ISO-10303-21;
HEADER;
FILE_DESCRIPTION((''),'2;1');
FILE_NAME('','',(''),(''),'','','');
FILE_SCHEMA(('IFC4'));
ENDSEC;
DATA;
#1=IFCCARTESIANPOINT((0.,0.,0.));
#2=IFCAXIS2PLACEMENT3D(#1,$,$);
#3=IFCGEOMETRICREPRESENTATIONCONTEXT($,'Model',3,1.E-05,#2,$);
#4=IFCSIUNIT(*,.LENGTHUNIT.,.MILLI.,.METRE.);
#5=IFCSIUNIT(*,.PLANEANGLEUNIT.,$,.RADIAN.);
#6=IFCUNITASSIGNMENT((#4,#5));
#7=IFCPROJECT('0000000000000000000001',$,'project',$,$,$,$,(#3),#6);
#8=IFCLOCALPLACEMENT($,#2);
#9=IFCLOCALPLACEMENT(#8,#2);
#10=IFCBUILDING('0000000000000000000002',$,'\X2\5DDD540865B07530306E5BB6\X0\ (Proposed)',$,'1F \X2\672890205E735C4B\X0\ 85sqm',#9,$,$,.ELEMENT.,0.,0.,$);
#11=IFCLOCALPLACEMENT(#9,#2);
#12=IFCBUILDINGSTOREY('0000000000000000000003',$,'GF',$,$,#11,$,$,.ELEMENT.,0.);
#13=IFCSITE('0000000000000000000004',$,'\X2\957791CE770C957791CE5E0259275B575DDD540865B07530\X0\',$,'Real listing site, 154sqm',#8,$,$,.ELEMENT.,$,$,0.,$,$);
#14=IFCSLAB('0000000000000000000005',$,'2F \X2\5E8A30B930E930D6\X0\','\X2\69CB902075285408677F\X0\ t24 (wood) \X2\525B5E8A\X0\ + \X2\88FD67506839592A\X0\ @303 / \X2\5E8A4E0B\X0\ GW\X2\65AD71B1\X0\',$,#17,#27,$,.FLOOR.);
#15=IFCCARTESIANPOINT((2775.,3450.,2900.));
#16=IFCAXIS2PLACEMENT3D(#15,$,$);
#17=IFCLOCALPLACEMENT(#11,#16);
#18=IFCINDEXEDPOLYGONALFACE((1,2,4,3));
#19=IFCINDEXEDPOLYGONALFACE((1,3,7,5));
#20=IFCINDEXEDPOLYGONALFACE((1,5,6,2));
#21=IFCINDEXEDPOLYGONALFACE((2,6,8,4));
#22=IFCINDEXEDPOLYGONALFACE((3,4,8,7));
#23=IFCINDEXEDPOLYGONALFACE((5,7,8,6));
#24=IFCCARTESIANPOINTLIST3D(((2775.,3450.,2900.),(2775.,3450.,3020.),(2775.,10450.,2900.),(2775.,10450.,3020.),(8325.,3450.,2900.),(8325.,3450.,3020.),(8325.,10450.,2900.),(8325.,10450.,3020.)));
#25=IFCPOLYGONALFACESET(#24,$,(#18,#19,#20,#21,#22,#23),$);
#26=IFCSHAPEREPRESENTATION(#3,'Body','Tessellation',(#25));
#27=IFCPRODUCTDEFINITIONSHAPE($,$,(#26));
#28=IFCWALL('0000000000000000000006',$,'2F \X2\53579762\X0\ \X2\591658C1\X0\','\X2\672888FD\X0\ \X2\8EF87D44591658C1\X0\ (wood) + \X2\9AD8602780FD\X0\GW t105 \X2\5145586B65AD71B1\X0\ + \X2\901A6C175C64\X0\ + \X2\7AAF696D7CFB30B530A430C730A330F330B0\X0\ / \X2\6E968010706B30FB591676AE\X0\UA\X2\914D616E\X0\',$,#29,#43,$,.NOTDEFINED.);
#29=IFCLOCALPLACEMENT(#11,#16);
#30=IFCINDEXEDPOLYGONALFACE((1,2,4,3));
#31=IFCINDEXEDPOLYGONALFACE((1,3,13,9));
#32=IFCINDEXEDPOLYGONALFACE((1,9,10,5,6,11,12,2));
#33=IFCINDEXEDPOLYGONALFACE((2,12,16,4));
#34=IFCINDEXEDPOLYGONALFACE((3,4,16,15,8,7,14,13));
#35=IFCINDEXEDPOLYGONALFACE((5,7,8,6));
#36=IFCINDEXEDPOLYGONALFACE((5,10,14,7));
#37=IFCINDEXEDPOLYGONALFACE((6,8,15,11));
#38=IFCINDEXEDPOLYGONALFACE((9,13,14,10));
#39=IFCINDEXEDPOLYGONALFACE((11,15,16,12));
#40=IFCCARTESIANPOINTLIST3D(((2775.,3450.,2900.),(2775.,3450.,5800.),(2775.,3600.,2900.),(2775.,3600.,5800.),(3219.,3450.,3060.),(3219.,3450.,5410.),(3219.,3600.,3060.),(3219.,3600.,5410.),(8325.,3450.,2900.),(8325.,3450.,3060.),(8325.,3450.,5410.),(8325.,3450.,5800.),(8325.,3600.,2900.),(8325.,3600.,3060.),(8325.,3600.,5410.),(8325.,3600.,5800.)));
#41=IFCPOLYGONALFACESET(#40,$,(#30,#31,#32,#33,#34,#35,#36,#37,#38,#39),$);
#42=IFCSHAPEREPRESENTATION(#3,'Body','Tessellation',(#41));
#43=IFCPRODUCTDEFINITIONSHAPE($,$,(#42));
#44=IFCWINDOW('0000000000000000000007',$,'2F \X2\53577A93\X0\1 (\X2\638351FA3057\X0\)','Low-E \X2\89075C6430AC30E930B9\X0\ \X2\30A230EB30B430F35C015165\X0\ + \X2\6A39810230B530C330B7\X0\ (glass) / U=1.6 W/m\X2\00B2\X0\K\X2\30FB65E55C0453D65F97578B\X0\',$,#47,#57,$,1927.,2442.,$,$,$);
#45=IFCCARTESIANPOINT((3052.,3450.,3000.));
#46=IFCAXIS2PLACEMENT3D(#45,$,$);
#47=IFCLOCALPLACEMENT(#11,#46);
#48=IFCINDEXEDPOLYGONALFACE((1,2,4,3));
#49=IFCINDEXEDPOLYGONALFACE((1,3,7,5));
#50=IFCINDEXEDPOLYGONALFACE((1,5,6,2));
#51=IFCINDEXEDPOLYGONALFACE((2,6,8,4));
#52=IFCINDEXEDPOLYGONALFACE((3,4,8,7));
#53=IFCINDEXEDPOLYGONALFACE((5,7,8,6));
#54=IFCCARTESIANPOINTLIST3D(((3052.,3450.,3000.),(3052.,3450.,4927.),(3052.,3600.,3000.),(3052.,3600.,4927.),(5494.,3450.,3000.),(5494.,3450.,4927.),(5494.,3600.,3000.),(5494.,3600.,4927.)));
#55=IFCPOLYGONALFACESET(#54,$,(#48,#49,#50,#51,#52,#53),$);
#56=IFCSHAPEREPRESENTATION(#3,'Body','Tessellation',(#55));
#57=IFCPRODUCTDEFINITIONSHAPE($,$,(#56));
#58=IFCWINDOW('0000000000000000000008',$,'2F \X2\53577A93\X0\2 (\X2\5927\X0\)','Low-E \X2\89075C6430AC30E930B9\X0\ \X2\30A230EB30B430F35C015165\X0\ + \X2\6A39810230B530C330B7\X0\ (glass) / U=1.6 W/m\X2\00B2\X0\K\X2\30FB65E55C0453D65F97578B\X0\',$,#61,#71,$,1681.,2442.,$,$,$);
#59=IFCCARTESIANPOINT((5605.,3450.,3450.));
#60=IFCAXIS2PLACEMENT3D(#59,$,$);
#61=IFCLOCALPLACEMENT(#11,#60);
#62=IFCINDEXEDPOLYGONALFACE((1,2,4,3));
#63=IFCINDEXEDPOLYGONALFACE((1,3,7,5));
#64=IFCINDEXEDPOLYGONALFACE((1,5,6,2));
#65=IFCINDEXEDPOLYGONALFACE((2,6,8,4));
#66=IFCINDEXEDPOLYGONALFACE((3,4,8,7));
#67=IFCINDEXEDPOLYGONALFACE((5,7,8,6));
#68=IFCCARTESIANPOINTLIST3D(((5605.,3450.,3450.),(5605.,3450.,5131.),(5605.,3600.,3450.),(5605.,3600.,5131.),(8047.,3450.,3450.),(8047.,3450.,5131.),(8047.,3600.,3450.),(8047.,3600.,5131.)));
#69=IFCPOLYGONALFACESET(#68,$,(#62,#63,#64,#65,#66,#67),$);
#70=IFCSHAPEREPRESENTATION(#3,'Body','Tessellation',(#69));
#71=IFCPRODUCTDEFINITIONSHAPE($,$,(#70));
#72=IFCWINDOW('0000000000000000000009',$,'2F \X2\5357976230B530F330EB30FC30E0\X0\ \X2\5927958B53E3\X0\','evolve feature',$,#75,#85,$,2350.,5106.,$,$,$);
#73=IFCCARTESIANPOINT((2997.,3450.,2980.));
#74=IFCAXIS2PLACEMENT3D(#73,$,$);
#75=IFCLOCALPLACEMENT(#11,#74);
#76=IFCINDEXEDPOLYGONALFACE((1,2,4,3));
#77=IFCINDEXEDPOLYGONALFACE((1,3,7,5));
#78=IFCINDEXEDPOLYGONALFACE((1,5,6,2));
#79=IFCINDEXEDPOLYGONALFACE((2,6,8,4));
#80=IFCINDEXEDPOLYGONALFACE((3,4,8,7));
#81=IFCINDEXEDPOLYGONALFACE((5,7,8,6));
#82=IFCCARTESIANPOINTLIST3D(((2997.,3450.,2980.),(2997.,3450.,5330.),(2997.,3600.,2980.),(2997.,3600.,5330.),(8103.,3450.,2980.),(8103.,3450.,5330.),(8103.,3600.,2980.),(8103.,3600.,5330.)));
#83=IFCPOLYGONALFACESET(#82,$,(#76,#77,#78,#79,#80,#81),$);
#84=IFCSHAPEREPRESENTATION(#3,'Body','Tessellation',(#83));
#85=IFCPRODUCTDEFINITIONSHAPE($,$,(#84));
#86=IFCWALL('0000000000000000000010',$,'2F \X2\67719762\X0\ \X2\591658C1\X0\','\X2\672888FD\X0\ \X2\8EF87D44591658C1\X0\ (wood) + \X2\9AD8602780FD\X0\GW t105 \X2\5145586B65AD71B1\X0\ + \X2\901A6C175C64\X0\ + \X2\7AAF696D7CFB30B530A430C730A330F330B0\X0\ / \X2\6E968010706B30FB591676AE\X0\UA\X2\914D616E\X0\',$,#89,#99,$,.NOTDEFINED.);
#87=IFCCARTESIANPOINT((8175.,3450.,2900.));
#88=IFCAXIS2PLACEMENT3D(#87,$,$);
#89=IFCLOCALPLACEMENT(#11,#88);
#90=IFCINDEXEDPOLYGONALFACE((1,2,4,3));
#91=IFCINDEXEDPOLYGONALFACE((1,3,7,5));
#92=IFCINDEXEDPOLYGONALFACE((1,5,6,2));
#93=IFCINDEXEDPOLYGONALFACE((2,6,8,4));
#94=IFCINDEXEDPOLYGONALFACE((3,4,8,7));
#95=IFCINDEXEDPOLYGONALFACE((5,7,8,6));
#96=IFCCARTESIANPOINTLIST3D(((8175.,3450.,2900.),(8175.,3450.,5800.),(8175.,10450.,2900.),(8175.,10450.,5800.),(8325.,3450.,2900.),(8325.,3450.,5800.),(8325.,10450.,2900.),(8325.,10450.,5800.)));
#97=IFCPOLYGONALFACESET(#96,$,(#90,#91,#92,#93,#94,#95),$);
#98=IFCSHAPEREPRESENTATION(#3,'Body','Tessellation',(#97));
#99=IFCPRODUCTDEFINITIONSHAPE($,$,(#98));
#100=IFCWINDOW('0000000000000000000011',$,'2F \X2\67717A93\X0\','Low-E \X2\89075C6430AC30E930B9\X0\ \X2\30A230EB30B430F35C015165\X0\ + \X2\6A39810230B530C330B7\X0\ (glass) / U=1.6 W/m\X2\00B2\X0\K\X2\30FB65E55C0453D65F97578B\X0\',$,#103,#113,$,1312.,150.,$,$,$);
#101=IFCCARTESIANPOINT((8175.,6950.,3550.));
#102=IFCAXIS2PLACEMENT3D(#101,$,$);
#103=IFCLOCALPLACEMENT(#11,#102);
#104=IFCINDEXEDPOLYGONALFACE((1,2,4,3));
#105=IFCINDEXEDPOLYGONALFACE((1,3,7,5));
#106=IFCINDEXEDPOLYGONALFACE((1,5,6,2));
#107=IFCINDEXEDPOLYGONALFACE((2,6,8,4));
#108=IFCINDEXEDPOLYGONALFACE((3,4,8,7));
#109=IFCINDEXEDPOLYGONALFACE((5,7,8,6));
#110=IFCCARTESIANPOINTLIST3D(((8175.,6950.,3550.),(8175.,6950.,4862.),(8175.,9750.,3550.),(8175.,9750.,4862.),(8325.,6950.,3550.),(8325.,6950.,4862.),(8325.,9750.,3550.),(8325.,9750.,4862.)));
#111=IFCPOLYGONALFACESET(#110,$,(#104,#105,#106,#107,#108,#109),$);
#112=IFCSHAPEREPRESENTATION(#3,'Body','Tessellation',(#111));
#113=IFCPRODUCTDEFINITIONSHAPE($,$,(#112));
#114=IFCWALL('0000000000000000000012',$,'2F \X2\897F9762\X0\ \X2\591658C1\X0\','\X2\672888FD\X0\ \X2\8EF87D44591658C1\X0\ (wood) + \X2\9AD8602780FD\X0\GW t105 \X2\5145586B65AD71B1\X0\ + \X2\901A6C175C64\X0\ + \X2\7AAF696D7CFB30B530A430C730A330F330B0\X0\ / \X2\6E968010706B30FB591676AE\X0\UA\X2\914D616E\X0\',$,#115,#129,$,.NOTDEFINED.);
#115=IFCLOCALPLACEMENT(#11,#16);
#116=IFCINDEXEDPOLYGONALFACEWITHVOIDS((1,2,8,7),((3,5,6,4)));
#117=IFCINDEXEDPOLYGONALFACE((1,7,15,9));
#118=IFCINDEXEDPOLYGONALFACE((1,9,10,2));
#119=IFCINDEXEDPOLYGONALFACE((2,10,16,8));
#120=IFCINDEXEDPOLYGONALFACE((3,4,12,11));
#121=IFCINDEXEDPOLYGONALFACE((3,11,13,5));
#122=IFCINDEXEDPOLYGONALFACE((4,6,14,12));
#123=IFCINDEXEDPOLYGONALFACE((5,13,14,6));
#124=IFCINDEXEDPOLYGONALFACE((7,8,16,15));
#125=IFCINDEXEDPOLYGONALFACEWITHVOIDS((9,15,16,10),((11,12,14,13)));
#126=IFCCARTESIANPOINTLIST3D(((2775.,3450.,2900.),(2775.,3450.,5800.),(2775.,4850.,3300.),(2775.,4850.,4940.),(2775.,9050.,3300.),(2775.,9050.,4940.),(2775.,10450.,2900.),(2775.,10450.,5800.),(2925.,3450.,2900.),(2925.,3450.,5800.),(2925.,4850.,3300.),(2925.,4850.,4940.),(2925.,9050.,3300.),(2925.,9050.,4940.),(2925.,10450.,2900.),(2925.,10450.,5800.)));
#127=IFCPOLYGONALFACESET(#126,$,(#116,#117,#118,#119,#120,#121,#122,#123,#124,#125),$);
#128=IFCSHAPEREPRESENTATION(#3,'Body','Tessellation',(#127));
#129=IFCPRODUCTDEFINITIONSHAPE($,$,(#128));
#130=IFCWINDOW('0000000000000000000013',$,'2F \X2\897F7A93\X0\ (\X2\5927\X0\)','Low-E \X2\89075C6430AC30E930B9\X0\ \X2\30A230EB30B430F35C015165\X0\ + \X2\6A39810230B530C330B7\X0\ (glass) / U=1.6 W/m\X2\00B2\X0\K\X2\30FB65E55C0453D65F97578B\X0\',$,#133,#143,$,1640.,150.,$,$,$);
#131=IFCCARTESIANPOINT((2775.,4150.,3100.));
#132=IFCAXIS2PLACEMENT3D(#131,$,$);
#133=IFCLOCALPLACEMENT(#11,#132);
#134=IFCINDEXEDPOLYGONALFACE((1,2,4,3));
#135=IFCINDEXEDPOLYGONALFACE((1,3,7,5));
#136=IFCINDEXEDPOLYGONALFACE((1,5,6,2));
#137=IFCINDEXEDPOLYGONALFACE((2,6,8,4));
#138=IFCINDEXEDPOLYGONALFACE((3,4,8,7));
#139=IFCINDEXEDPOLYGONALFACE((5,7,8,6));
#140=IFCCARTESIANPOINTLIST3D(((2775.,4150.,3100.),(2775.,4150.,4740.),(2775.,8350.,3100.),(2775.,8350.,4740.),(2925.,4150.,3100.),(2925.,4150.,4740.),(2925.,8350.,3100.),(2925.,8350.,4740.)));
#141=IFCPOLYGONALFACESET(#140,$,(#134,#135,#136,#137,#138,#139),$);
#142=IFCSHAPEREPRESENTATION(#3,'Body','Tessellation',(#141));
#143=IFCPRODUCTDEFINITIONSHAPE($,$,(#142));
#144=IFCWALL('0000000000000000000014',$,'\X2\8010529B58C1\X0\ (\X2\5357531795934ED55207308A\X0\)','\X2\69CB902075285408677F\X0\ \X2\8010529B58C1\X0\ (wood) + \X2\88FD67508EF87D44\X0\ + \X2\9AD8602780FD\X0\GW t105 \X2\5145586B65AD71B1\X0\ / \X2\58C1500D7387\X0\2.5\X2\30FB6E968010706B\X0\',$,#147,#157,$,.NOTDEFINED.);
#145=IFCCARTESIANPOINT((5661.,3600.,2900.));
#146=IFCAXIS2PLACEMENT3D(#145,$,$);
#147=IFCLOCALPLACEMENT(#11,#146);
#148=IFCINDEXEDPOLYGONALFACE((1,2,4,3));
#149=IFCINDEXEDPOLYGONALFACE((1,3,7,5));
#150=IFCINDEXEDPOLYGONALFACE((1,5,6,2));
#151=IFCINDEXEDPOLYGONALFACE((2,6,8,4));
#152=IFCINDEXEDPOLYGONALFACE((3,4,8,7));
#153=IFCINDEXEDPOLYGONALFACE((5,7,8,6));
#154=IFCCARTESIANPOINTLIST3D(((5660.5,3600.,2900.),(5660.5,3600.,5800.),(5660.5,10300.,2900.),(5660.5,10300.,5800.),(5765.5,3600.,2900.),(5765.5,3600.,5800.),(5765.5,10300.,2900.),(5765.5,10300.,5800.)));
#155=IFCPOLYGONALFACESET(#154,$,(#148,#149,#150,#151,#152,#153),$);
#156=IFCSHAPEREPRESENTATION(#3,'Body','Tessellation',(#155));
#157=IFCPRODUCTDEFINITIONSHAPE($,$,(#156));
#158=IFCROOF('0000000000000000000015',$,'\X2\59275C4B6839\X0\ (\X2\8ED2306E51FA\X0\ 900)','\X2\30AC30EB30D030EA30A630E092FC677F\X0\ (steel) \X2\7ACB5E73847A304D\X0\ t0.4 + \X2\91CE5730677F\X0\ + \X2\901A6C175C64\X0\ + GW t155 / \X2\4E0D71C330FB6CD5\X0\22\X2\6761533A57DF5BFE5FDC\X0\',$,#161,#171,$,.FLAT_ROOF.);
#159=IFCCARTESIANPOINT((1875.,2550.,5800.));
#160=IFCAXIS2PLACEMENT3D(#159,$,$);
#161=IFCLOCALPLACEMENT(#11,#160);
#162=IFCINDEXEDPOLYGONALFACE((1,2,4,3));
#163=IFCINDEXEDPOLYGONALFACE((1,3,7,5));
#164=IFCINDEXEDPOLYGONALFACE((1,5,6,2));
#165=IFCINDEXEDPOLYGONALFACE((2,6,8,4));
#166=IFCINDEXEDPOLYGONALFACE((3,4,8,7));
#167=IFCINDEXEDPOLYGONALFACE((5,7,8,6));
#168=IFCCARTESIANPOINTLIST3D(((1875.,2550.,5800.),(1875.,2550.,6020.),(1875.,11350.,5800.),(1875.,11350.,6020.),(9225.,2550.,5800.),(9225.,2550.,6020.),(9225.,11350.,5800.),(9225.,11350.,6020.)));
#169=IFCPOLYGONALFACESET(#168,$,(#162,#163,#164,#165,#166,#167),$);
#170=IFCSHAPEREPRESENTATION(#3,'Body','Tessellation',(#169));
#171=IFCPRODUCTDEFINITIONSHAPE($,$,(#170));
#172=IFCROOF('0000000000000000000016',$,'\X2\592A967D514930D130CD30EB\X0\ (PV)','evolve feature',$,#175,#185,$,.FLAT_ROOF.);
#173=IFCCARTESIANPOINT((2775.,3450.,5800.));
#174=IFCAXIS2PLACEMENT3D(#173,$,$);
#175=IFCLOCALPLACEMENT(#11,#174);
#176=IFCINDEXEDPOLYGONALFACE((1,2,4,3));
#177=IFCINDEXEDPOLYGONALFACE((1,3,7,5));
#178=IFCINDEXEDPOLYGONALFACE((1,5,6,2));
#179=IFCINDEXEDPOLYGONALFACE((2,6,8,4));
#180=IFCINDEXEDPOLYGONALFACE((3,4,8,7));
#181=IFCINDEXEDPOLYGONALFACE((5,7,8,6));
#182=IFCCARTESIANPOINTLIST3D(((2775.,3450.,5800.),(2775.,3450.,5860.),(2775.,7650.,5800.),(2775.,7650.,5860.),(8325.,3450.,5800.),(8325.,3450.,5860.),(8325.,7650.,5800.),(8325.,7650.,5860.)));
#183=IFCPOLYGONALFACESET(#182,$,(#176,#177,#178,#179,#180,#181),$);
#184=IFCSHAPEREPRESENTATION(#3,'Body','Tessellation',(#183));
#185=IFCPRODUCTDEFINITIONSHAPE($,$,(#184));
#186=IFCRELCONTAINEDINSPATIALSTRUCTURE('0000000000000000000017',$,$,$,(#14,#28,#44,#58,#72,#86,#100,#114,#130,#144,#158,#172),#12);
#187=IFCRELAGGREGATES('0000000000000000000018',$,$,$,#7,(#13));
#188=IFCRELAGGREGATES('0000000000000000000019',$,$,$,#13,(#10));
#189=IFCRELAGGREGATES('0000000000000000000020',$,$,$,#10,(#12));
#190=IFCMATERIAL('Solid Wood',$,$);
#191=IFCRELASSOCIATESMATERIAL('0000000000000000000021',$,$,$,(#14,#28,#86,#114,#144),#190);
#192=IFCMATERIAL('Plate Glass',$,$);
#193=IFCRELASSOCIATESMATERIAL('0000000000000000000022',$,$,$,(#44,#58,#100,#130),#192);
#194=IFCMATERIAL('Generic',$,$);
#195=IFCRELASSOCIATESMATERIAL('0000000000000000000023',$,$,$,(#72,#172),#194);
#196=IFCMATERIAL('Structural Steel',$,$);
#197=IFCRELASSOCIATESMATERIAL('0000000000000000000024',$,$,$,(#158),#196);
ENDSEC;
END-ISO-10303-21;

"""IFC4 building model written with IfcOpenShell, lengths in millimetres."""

from ifc_helpers import new_model, si_unit, frame, frame_2d, origin, place, context, project, spatial, rectangle, extrude, material, element, fill, save


model = new_model("IFC4")

# Units and contexts
model_context = context("Model", 3, precision=1e-05, world=origin())
ifc_project = project(units=[si_unit("LENGTHUNIT", "METRE", prefix="MILLI"), si_unit("PLANEANGLEUNIT", "RADIAN")], contexts=[model_context])

# Site, building, storey
site_placement = place(None, origin())
site = spatial("IfcSite", under=ifc_project, at=site_placement, Name="長野県長野市大字川合新田", ObjectType="Real listing site, 154sqm", CompositionType="ELEMENT", RefElevation=0.0)
building_placement = place(site_placement, origin())
building = spatial("IfcBuilding", under=site, at=building_placement, Name="川合新田の家 (Proposed)", ObjectType="1F 木造平屋 85sqm", CompositionType="ELEMENT", ElevationOfRefHeight=0.0, ElevationOfTerrain=0.0)
storey_placement = place(building_placement, origin())
storey = spatial("IfcBuildingStorey", under=building, at=storey_placement, Name="GF", CompositionType="ELEMENT", Elevation=0.0)

# Slab
ifc_material_1 = material(Name="Solid Wood")
slab_placement = place(storey_placement, frame((2775.0, 3450.0, 2900.0)))
element("IfcSlab", 1, at=slab_placement, inside=storey, material=ifc_material_1, Name="2F 床スラブ", Description="構造用合板 t24 (wood) 剛床 + 製材根太 @303 / 床下 GW断熱", PredefinedType="FLOOR", context=model_context, shape_type="SweptSolid", body=[
    extrude(rectangle(XDim=5550.0, YDim=7000.0, at=frame_2d((2775.0, 3500.0))), frame((2775.0, 3450.0, 2900.0)), (0.0, 0.0, 1.0), 120.0),
])

# Wall, openings, windows
wall_1_placement = place(storey_placement, frame((2775.0, 3450.0, 2900.0)))
wall_1 = element("IfcWall", 2, at=wall_1_placement, inside=storey, material=ifc_material_1, Name="2F 南面 外壁", Description="木製 軸組外壁 (wood) + 高性能GW t105 充填断熱 + 通気層 + 窯業系サイディング / 準耐火・外皮UA配慮", PredefinedType="NOTDEFINED", context=model_context, shape_type="SweptSolid", body=[
    extrude(rectangle(XDim=5550.0, YDim=150.0, at=frame_2d((2775.0, 75.0))), frame((2775.0, 3450.0, 2900.0)), (0.0, 0.0, 1.0), 2900.0),
])
opening_1_placement = place(storey_placement, frame((3052.0, 3450.0, 3000.0)))
opening_1 = element("IfcOpeningElement", 3, at=opening_1_placement, cuts=wall_1, PredefinedType="NOTDEFINED", context=model_context, shape_type="SweptSolid", body=[
    extrude(rectangle(XDim=2442.0, YDim=150.0, at=frame_2d((1221.0, 75.0))), frame((3052.0, 3450.0, 3000.0)), (0.0, 0.0, 1.0), 1927.0),
])
opening_2_placement = place(storey_placement, frame((5605.0, 3450.0, 3450.0)))
opening_2 = element("IfcOpeningElement", 4, at=opening_2_placement, cuts=wall_1, PredefinedType="NOTDEFINED", context=model_context, shape_type="SweptSolid", body=[
    extrude(rectangle(XDim=2442.0, YDim=150.0, at=frame_2d((1221.0, 75.0))), frame((5605.0, 3450.0, 3450.0)), (0.0, 0.0, 1.0), 1681.0),
])
opening_3_placement = place(storey_placement, frame((2997.0, 3450.0, 2980.0)))
opening_3 = element("IfcOpeningElement", 5, at=opening_3_placement, cuts=wall_1, PredefinedType="NOTDEFINED", context=model_context, shape_type="SweptSolid", body=[
    extrude(rectangle(XDim=5106.0, YDim=150.0, at=frame_2d((2553.0, 75.0))), frame((2997.0, 3450.0, 2980.0)), (0.0, 0.0, 1.0), 2350.0),
])
ifc_material_2 = material(Name="Plate Glass")
window_1_placement = place(storey_placement, frame((3052.0, 3450.0, 3000.0)))
window_1 = element("IfcWindow", 6, at=window_1_placement, inside=storey, material=ifc_material_2, Name="2F 南窓1 (掃出し)", Description="Low-E 複層ガラス アルゴン封入 + 樹脂サッシ (glass) / U=1.6 W/m²K・日射取得型", OverallHeight=1927.0, OverallWidth=2442.0, context=model_context, shape_type="SweptSolid", body=[
    extrude(rectangle(XDim=2442.0, YDim=150.0, at=frame_2d((1221.0, 75.0))), frame((3052.0, 3450.0, 3000.0)), (0.0, 0.0, 1.0), 1927.0),
])
fill(opening_1, window_1)
window_2_placement = place(storey_placement, frame((5605.0, 3450.0, 3450.0)))
window_2 = element("IfcWindow", 7, at=window_2_placement, inside=storey, material=ifc_material_2, Name="2F 南窓2 (大)", Description="Low-E 複層ガラス アルゴン封入 + 樹脂サッシ (glass) / U=1.6 W/m²K・日射取得型", OverallHeight=1681.0, OverallWidth=2442.0, context=model_context, shape_type="SweptSolid", body=[
    extrude(rectangle(XDim=2442.0, YDim=150.0, at=frame_2d((1221.0, 75.0))), frame((5605.0, 3450.0, 3450.0)), (0.0, 0.0, 1.0), 1681.0),
])
fill(opening_2, window_2)
ifc_material_3 = material(Name="Generic")
window_3_placement = place(storey_placement, frame((2997.0, 3450.0, 2980.0)))
window_3 = element("IfcWindow", 8, at=window_3_placement, inside=storey, material=ifc_material_3, Name="2F 南面サンルーム 大開口", Description="evolve feature", OverallHeight=2350.0, OverallWidth=5106.0, context=model_context, shape_type="SweptSolid", body=[
    extrude(rectangle(XDim=5106.0, YDim=150.0, at=frame_2d((2553.0, 75.0))), frame((2997.0, 3450.0, 2980.0)), (0.0, 0.0, 1.0), 2350.0),
])
fill(opening_3, window_3)

# Walls, openings, windows
wall_2_placement = place(storey_placement, frame((8175.0, 3450.0, 2900.0)))
wall_2 = element("IfcWall", 9, at=wall_2_placement, inside=storey, material=ifc_material_1, Name="2F 東面 外壁", Description="木製 軸組外壁 (wood) + 高性能GW t105 充填断熱 + 通気層 + 窯業系サイディング / 準耐火・外皮UA配慮", PredefinedType="NOTDEFINED", context=model_context, shape_type="SweptSolid", body=[
    extrude(rectangle(XDim=150.0, YDim=7000.0, at=frame_2d((75.0, 3500.0))), frame((8175.0, 3450.0, 2900.0)), (0.0, 0.0, 1.0), 2900.0),
])
opening_4_placement = place(storey_placement, frame((8175.0, 6950.0, 3550.0)))
opening_4 = element("IfcOpeningElement", 10, at=opening_4_placement, cuts=wall_2, PredefinedType="NOTDEFINED", context=model_context, shape_type="SweptSolid", body=[
    extrude(rectangle(XDim=150.0, YDim=2800.0, at=frame_2d((75.0, 1400.0))), frame((8175.0, 6950.0, 3550.0)), (0.0, 0.0, 1.0), 1312.0),
])
window_4_placement = place(storey_placement, frame((8175.0, 6950.0, 3550.0)))
window_4 = element("IfcWindow", 11, at=window_4_placement, inside=storey, material=ifc_material_2, Name="2F 東窓", Description="Low-E 複層ガラス アルゴン封入 + 樹脂サッシ (glass) / U=1.6 W/m²K・日射取得型", OverallHeight=1312.0, OverallWidth=150.0, context=model_context, shape_type="SweptSolid", body=[
    extrude(rectangle(XDim=150.0, YDim=2800.0, at=frame_2d((75.0, 1400.0))), frame((8175.0, 6950.0, 3550.0)), (0.0, 0.0, 1.0), 1312.0),
])
fill(opening_4, window_4)
wall_3_placement = place(storey_placement, frame((2775.0, 3450.0, 2900.0)))
wall_3 = element("IfcWall", 12, at=wall_3_placement, inside=storey, material=ifc_material_1, Name="2F 西面 外壁", Description="木製 軸組外壁 (wood) + 高性能GW t105 充填断熱 + 通気層 + 窯業系サイディング / 準耐火・外皮UA配慮", PredefinedType="NOTDEFINED", context=model_context, shape_type="SweptSolid", body=[
    extrude(rectangle(XDim=150.0, YDim=7000.0, at=frame_2d((75.0, 3500.0))), frame((2775.0, 3450.0, 2900.0)), (0.0, 0.0, 1.0), 2900.0),
])
opening_5_placement = place(storey_placement, frame((2775.0, 4150.0, 3100.0)))
opening_5 = element("IfcOpeningElement", 13, at=opening_5_placement, cuts=wall_3, PredefinedType="NOTDEFINED", context=model_context, shape_type="SweptSolid", body=[
    extrude(rectangle(XDim=150.0, YDim=4200.0, at=frame_2d((75.0, 2100.0))), frame((2775.0, 4150.0, 3100.0)), (0.0, 0.0, 1.0), 1640.0),
])
window_5_placement = place(storey_placement, frame((2775.0, 4150.0, 3100.0)))
window_5 = element("IfcWindow", 14, at=window_5_placement, inside=storey, material=ifc_material_2, Name="2F 西窓 (大)", Description="Low-E 複層ガラス アルゴン封入 + 樹脂サッシ (glass) / U=1.6 W/m²K・日射取得型", OverallHeight=1640.0, OverallWidth=150.0, context=model_context, shape_type="SweptSolid", body=[
    extrude(rectangle(XDim=150.0, YDim=4200.0, at=frame_2d((75.0, 2100.0))), frame((2775.0, 4150.0, 3100.0)), (0.0, 0.0, 1.0), 1640.0),
])
fill(opening_5, window_5)

# Wall
wall_4_placement = place(storey_placement, frame((5661.0, 3600.0, 2900.0)))
element("IfcWall", 15, at=wall_4_placement, inside=storey, material=ifc_material_1, Name="耐力壁 (南北間仕切り)", Description="構造用合板 耐力壁 (wood) + 製材軸組 + 高性能GW t105 充填断熱 / 壁倍率2.5・準耐火", PredefinedType="NOTDEFINED", context=model_context, shape_type="SweptSolid", body=[
    extrude(rectangle(XDim=105.0, YDim=6700.0, at=frame_2d((52.0, 3350.0))), frame((5661.0, 3600.0, 2900.0)), (0.0, 0.0, 1.0), 2900.0),
])

# Roofs
ifc_material_4 = material(Name="Structural Steel")
roof_1_placement = place(storey_placement, frame((1875.0, 2550.0, 5800.0)))
element("IfcRoof", 16, at=roof_1_placement, inside=storey, material=ifc_material_4, Name="大屋根 (軒の出 900)", Description="ガルバリウム鋼板 (steel) 立平葺き t0.4 + 野地板 + 通気層 + GW t155 / 不燃・法22条区域対応", PredefinedType="FLAT_ROOF", context=model_context, shape_type="SweptSolid", body=[
    extrude(rectangle(XDim=7350.0, YDim=8800.0, at=frame_2d((3675.0, 4400.0))), frame((1875.0, 2550.0, 5800.0)), (0.0, 0.0, 1.0), 220.0),
])
roof_2_placement = place(storey_placement, frame((2775.0, 3450.0, 5800.0)))
element("IfcRoof", 17, at=roof_2_placement, inside=storey, material=ifc_material_3, Name="太陽光パネル (PV)", Description="evolve feature", PredefinedType="FLAT_ROOF", context=model_context, shape_type="SweptSolid", body=[
    extrude(rectangle(XDim=5550.0, YDim=4200.0, at=frame_2d((2775.0, 2100.0))), frame((2775.0, 3450.0, 5800.0)), (0.0, 0.0, 1.0), 60.0),
])

save(model, "model.ifc")
